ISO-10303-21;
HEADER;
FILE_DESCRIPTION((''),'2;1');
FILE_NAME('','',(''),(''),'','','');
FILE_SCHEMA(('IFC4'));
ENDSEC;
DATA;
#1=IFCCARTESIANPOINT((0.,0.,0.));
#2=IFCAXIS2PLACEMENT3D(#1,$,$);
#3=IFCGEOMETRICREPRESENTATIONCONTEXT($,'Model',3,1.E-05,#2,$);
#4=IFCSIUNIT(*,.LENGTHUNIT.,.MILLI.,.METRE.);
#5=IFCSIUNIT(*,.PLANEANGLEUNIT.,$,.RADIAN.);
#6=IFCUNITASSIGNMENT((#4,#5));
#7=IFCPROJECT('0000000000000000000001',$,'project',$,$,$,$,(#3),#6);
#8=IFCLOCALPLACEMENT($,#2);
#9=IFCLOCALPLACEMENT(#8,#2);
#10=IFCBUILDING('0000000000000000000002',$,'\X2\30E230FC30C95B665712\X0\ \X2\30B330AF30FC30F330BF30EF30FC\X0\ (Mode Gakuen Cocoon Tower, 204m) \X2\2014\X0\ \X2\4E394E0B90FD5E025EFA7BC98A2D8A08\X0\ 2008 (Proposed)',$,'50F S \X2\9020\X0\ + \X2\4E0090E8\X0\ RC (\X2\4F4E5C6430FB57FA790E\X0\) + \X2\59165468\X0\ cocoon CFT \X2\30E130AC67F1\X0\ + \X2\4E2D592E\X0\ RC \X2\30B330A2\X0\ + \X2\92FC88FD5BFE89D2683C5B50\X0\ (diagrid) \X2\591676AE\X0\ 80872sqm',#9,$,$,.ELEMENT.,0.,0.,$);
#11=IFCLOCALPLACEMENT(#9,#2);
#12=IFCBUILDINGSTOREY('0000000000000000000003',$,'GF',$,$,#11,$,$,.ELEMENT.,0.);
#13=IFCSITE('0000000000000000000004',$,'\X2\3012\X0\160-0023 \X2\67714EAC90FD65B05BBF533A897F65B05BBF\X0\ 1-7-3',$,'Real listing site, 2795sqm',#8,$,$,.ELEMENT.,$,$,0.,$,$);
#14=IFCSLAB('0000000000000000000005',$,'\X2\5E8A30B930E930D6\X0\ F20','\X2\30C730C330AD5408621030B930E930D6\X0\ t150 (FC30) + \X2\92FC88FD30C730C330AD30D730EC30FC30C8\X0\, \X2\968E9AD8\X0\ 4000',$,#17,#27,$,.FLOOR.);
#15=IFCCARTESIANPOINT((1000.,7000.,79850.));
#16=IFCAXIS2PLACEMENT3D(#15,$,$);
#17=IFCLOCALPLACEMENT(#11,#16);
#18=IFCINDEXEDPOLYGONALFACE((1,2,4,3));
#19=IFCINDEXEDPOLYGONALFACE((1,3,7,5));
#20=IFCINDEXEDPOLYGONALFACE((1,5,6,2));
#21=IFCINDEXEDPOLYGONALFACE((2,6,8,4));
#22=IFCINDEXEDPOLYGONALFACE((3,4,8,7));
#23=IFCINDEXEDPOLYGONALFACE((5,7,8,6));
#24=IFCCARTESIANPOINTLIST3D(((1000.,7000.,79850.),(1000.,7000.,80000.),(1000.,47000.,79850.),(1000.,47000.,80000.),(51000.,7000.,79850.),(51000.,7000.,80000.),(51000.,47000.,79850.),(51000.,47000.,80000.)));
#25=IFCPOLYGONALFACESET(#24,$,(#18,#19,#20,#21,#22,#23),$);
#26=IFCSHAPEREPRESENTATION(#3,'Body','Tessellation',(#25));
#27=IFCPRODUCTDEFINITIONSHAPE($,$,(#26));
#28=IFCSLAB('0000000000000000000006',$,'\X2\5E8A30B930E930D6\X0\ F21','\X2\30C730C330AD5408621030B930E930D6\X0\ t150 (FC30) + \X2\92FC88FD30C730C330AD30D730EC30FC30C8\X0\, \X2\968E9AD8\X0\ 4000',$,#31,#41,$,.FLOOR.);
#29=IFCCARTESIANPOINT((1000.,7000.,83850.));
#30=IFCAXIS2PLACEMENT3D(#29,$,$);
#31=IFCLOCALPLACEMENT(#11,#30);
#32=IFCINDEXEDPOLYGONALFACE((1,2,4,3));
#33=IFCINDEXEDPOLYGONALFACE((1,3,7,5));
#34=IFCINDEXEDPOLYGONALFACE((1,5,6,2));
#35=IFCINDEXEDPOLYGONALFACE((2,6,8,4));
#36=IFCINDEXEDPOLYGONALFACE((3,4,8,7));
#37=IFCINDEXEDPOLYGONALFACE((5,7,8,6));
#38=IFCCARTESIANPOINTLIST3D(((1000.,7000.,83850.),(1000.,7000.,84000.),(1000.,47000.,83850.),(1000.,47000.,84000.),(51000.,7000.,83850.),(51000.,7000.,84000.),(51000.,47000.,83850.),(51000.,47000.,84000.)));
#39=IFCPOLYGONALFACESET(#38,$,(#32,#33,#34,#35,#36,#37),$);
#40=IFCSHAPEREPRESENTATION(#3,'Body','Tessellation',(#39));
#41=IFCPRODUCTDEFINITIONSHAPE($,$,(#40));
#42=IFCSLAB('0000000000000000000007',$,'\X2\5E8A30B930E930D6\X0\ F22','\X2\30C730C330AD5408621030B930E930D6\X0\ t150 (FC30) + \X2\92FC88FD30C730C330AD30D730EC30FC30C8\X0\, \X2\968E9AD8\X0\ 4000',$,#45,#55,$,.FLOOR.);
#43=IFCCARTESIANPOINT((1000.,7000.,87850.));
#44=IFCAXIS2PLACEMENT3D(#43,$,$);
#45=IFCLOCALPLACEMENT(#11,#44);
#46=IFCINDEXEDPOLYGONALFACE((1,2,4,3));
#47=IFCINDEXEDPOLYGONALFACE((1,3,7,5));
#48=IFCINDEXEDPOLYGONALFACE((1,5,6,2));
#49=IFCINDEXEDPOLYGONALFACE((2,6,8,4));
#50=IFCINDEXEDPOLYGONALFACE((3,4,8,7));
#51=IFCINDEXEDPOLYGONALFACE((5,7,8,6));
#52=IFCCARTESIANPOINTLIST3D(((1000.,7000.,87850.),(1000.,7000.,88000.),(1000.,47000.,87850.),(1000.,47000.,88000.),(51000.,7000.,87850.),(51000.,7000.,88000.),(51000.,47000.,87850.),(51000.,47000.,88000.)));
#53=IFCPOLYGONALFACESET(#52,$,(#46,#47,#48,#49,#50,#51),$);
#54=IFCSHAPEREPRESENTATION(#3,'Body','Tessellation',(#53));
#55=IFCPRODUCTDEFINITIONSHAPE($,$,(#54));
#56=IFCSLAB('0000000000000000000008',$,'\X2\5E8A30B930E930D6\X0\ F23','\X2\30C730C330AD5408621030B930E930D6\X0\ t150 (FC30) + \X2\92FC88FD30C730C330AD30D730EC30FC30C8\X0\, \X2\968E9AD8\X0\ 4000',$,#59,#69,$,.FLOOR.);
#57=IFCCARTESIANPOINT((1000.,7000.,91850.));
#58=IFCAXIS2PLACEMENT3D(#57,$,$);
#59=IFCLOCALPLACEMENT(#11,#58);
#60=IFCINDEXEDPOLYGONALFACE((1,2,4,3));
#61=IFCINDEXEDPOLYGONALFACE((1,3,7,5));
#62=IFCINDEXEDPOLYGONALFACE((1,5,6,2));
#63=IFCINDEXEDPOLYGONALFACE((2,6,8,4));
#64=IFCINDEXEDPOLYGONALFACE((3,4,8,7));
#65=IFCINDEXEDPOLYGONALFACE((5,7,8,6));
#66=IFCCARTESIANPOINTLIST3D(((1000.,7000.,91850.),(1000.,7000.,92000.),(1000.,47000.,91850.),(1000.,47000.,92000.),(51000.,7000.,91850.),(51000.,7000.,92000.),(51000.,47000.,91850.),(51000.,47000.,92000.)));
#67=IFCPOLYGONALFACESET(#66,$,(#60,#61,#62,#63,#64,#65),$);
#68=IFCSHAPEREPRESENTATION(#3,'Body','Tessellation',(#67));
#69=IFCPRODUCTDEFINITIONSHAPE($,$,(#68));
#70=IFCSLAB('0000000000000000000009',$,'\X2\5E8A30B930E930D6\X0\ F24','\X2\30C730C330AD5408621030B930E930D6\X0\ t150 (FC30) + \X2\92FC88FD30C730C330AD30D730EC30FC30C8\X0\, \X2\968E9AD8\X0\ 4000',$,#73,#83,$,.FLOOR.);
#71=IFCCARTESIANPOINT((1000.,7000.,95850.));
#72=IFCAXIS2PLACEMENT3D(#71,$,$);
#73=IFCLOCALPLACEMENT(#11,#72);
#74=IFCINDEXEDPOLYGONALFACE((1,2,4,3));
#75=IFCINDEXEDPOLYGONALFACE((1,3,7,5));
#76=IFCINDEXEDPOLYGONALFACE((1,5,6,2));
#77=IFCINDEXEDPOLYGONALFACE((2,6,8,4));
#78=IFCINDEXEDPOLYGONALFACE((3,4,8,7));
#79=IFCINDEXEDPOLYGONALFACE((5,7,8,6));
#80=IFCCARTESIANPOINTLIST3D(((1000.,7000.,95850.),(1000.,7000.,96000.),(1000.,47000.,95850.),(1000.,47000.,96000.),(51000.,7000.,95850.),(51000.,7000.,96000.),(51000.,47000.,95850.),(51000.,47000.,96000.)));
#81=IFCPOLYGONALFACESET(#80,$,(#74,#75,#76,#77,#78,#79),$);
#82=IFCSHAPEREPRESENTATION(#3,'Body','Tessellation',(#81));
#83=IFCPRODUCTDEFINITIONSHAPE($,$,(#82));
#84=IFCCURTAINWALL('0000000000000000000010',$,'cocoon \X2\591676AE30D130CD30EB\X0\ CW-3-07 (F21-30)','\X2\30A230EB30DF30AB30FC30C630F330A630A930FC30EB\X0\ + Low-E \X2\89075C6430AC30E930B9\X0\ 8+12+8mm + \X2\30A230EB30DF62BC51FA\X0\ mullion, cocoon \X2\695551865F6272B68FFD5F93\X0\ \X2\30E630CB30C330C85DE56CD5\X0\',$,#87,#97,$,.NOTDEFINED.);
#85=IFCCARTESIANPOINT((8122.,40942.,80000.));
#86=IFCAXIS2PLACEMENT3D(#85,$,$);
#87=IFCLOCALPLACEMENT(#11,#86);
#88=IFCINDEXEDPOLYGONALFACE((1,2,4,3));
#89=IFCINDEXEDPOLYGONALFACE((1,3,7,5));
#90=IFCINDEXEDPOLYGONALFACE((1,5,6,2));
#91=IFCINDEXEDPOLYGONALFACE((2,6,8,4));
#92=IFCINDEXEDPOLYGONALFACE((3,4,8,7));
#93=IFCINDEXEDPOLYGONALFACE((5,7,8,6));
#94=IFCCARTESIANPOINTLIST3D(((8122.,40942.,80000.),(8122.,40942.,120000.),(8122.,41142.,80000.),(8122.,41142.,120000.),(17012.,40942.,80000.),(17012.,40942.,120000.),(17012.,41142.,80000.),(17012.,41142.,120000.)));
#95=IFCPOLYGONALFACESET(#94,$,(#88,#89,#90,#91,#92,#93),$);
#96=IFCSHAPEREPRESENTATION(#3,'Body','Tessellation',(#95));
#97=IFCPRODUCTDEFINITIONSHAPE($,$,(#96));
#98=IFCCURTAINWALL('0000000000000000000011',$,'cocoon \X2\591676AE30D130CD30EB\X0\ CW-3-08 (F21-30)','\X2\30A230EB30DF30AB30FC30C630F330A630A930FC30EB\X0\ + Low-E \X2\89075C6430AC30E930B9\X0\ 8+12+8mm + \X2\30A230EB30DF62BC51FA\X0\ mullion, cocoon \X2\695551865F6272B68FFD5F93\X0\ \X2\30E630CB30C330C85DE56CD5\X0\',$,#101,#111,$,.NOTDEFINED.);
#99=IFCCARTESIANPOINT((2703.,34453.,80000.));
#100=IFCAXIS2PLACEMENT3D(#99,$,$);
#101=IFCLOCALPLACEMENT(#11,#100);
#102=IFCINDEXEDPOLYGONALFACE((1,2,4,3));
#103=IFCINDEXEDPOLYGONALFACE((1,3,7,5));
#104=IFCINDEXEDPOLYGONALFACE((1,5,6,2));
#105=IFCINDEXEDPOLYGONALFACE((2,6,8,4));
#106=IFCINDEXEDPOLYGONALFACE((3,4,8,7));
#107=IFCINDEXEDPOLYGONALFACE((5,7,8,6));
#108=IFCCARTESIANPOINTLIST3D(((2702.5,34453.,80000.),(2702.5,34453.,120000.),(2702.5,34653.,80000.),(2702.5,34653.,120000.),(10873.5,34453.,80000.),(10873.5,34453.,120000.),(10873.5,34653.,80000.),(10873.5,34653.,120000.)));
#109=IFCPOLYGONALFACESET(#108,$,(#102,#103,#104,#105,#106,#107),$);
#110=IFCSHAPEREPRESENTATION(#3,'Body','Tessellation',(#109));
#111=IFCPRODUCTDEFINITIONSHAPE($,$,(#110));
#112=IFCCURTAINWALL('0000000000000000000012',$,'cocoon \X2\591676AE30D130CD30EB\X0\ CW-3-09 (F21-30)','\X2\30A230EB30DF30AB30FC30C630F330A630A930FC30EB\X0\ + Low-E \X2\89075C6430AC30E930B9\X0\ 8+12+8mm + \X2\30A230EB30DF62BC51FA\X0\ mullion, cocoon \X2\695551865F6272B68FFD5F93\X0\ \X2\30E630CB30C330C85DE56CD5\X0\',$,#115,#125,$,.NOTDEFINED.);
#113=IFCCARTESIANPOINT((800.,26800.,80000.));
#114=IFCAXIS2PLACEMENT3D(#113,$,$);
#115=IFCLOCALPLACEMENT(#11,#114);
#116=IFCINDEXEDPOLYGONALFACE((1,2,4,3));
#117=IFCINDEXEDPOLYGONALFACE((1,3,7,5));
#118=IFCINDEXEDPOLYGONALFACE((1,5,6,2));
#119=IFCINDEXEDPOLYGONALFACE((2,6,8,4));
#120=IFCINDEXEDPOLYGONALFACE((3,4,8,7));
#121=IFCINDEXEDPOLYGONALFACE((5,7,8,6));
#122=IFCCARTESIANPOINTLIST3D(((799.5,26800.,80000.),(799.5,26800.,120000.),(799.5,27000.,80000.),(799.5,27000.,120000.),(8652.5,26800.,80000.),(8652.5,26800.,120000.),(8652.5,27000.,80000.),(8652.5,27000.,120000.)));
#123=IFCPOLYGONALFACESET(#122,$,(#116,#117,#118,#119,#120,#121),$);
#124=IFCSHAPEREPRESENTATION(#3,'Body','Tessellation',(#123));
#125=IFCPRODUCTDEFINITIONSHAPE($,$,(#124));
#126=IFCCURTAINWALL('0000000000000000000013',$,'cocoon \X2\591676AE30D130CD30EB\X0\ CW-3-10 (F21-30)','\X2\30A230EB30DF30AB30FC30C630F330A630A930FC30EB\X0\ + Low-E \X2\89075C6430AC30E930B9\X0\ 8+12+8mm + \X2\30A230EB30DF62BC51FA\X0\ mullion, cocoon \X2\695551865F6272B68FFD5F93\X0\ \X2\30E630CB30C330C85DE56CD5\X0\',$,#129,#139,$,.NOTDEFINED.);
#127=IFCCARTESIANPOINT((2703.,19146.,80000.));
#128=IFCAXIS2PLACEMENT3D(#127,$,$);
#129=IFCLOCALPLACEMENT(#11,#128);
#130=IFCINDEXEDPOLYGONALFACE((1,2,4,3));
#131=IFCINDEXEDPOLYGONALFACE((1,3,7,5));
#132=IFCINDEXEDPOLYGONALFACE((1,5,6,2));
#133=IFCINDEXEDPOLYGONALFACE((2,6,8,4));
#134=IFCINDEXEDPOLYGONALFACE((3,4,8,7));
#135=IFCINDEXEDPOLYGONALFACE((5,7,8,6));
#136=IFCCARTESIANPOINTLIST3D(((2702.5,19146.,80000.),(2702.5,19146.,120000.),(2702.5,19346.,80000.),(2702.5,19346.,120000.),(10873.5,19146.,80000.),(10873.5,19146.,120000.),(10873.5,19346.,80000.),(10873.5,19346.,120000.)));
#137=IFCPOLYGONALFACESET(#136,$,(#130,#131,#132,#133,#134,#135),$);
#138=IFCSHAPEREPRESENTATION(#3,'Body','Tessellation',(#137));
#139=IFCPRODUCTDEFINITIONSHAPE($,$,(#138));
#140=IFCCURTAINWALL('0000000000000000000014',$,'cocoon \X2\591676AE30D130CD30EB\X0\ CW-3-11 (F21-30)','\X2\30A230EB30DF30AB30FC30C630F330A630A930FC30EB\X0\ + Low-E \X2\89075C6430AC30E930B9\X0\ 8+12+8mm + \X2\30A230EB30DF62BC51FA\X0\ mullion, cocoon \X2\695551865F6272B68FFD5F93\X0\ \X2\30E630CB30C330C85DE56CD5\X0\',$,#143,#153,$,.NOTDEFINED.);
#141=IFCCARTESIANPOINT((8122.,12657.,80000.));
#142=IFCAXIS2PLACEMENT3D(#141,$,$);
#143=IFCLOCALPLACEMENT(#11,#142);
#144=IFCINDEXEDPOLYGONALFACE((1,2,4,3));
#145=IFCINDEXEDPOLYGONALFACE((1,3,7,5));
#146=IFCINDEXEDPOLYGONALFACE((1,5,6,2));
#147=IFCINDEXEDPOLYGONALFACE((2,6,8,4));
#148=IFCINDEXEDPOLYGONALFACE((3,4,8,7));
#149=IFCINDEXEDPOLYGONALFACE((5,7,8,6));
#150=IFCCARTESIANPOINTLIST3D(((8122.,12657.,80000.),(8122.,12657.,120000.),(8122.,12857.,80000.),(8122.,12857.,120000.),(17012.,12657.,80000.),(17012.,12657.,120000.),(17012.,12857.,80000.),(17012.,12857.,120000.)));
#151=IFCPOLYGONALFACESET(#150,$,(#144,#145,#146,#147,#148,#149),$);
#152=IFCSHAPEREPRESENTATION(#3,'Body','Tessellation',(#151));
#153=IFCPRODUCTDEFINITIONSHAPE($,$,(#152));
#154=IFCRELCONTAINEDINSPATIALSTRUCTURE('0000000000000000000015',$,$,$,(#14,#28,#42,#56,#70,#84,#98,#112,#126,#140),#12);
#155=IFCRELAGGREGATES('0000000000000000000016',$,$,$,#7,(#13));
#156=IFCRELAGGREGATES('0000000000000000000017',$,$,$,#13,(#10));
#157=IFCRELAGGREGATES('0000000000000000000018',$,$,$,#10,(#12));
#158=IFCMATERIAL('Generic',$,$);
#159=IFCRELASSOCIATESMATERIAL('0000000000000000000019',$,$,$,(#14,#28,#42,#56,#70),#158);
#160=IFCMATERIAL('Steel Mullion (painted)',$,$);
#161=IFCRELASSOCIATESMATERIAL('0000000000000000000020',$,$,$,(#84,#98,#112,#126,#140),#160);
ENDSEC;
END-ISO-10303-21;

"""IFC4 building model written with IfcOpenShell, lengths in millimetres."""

from ifc_helpers import new_model, si_unit, frame, frame_2d, origin, place, context, project, spatial, rectangle, extrude, material, element, save


model = new_model("IFC4")

# Units and contexts
model_context = context("Model", 3, precision=1e-05, world=origin())
ifc_project = project(units=[si_unit("LENGTHUNIT", "METRE", prefix="MILLI"), si_unit("PLANEANGLEUNIT", "RADIAN")], contexts=[model_context])

# Site, building, storey
site_placement = place(None, origin())
site = spatial("IfcSite", under=ifc_project, at=site_placement, Name="〒160-0023 東京都新宿区西新宿 1-7-3", ObjectType="Real listing site, 2795sqm", CompositionType="ELEMENT", RefElevation=0.0)
building_placement = place(site_placement, origin())
building = spatial("IfcBuilding", under=site, at=building_placement, Name="モード学園 コクーンタワー (Mode Gakuen Cocoon Tower, 204m) — 丹下都市建築設計 2008 (Proposed)", ObjectType="50F S 造 + 一部 RC (低層・基礎) + 外周 cocoon CFT メガ柱 + 中央 RC コア + 鋼製対角格子 (diagrid) 外皮 80872sqm", CompositionType="ELEMENT", ElevationOfRefHeight=0.0, ElevationOfTerrain=0.0)
storey_placement = place(building_placement, origin())
storey = spatial("IfcBuildingStorey", under=building, at=storey_placement, Name="GF", CompositionType="ELEMENT", Elevation=0.0)

# Shared definitions
ifc_material_1 = material(Name="Generic")

# Slabs
slab_1_placement = place(storey_placement, frame((1000.0, 7000.0, 79850.0)))
element("IfcSlab", 1, at=slab_1_placement, inside=storey, material=ifc_material_1, Name="床スラブ F20", Description="デッキ合成スラブ t150 (FC30) + 鋼製デッキプレート, 階高 4000", PredefinedType="FLOOR", context=model_context, shape_type="SweptSolid", body=[
    extrude(rectangle(XDim=50000.0, YDim=40000.0, at=frame_2d((25000.0, 20000.0))), frame((1000.0, 7000.0, 79850.0)), (0.0, 0.0, 1.0), 150.0),
])
slab_2_placement = place(storey_placement, frame((1000.0, 7000.0, 83850.0)))
element("IfcSlab", 2, at=slab_2_placement, inside=storey, material=ifc_material_1, Name="床スラブ F21", Description="デッキ合成スラブ t150 (FC30) + 鋼製デッキプレート, 階高 4000", PredefinedType="FLOOR", context=model_context, shape_type="SweptSolid", body=[
    extrude(rectangle(XDim=50000.0, YDim=40000.0, at=frame_2d((25000.0, 20000.0))), frame((1000.0, 7000.0, 83850.0)), (0.0, 0.0, 1.0), 150.0),
])
slab_3_placement = place(storey_placement, frame((1000.0, 7000.0, 87850.0)))
element("IfcSlab", 3, at=slab_3_placement, inside=storey, material=ifc_material_1, Name="床スラブ F22", Description="デッキ合成スラブ t150 (FC30) + 鋼製デッキプレート, 階高 4000", PredefinedType="FLOOR", context=model_context, shape_type="SweptSolid", body=[
    extrude(rectangle(XDim=50000.0, YDim=40000.0, at=frame_2d((25000.0, 20000.0))), frame((1000.0, 7000.0, 87850.0)), (0.0, 0.0, 1.0), 150.0),
])
slab_4_placement = place(storey_placement, frame((1000.0, 7000.0, 91850.0)))
element("IfcSlab", 4, at=slab_4_placement, inside=storey, material=ifc_material_1, Name="床スラブ F23", Description="デッキ合成スラブ t150 (FC30) + 鋼製デッキプレート, 階高 4000", PredefinedType="FLOOR", context=model_context, shape_type="SweptSolid", body=[
    extrude(rectangle(XDim=50000.0, YDim=40000.0, at=frame_2d((25000.0, 20000.0))), frame((1000.0, 7000.0, 91850.0)), (0.0, 0.0, 1.0), 150.0),
])
slab_5_placement = place(storey_placement, frame((1000.0, 7000.0, 95850.0)))
element("IfcSlab", 5, at=slab_5_placement, inside=storey, material=ifc_material_1, Name="床スラブ F24", Description="デッキ合成スラブ t150 (FC30) + 鋼製デッキプレート, 階高 4000", PredefinedType="FLOOR", context=model_context, shape_type="SweptSolid", body=[
    extrude(rectangle(XDim=50000.0, YDim=40000.0, at=frame_2d((25000.0, 20000.0))), frame((1000.0, 7000.0, 95850.0)), (0.0, 0.0, 1.0), 150.0),
])

# Curtain walls
ifc_material_2 = material(Name="Steel Mullion (painted)")
curtain_wall_1_placement = place(storey_placement, frame((8122.0, 40942.0, 80000.0)))
element("IfcCurtainWall", 6, at=curtain_wall_1_placement, inside=storey, material=ifc_material_2, Name="cocoon 外皮パネル CW-3-07 (F21-30)", Description="アルミカーテンウォール + Low-E 複層ガラス 8+12+8mm + アルミ押出 mullion, cocoon 楕円形状追従 ユニット工法", PredefinedType="NOTDEFINED", context=model_context, shape_type="SweptSolid", body=[
    extrude(rectangle(XDim=8890.0, YDim=200.0, at=frame_2d((4445.0, 100.0))), frame((8122.0, 40942.0, 80000.0)), (0.0, 0.0, 1.0), 40000.0),
])
curtain_wall_2_placement = place(storey_placement, frame((2703.0, 34453.0, 80000.0)))
element("IfcCurtainWall", 7, at=curtain_wall_2_placement, inside=storey, material=ifc_material_2, Name="cocoon 外皮パネル CW-3-08 (F21-30)", Description="アルミカーテンウォール + Low-E 複層ガラス 8+12+8mm + アルミ押出 mullion, cocoon 楕円形状追従 ユニット工法", PredefinedType="NOTDEFINED", context=model_context, shape_type="SweptSolid", body=[
    extrude(rectangle(XDim=8171.0, YDim=200.0, at=frame_2d((4085.0, 100.0))), frame((2703.0, 34453.0, 80000.0)), (0.0, 0.0, 1.0), 40000.0),
])
curtain_wall_3_placement = place(storey_placement, frame((800.0, 26800.0, 80000.0)))
element("IfcCurtainWall", 8, at=curtain_wall_3_placement, inside=storey, material=ifc_material_2, Name="cocoon 外皮パネル CW-3-09 (F21-30)", Description="アルミカーテンウォール + Low-E 複層ガラス 8+12+8mm + アルミ押出 mullion, cocoon 楕円形状追従 ユニット工法", PredefinedType="NOTDEFINED", context=model_context, shape_type="SweptSolid", body=[
    extrude(rectangle(XDim=7853.0, YDim=200.0, at=frame_2d((3926.0, 100.0))), frame((800.0, 26800.0, 80000.0)), (0.0, 0.0, 1.0), 40000.0),
])
curtain_wall_4_placement = place(storey_placement, frame((2703.0, 19146.0, 80000.0)))
element("IfcCurtainWall", 9, at=curtain_wall_4_placement, inside=storey, material=ifc_material_2, Name="cocoon 外皮パネル CW-3-10 (F21-30)", Description="アルミカーテンウォール + Low-E 複層ガラス 8+12+8mm + アルミ押出 mullion, cocoon 楕円形状追従 ユニット工法", PredefinedType="NOTDEFINED", context=model_context, shape_type="SweptSolid", body=[
    extrude(rectangle(XDim=8171.0, YDim=200.0, at=frame_2d((4085.0, 100.0))), frame((2703.0, 19146.0, 80000.0)), (0.0, 0.0, 1.0), 40000.0),
])
curtain_wall_5_placement = place(storey_placement, frame((8122.0, 12657.0, 80000.0)))
element("IfcCurtainWall", 10, at=curtain_wall_5_placement, inside=storey, material=ifc_material_2, Name="cocoon 外皮パネル CW-3-11 (F21-30)", Description="アルミカーテンウォール + Low-E 複層ガラス 8+12+8mm + アルミ押出 mullion, cocoon 楕円形状追従 ユニット工法", PredefinedType="NOTDEFINED", context=model_context, shape_type="SweptSolid", body=[
    extrude(rectangle(XDim=8890.0, YDim=200.0, at=frame_2d((4445.0, 100.0))), frame((8122.0, 12657.0, 80000.0)), (0.0, 0.0, 1.0), 40000.0),
])

save(model, "model.ifc")
